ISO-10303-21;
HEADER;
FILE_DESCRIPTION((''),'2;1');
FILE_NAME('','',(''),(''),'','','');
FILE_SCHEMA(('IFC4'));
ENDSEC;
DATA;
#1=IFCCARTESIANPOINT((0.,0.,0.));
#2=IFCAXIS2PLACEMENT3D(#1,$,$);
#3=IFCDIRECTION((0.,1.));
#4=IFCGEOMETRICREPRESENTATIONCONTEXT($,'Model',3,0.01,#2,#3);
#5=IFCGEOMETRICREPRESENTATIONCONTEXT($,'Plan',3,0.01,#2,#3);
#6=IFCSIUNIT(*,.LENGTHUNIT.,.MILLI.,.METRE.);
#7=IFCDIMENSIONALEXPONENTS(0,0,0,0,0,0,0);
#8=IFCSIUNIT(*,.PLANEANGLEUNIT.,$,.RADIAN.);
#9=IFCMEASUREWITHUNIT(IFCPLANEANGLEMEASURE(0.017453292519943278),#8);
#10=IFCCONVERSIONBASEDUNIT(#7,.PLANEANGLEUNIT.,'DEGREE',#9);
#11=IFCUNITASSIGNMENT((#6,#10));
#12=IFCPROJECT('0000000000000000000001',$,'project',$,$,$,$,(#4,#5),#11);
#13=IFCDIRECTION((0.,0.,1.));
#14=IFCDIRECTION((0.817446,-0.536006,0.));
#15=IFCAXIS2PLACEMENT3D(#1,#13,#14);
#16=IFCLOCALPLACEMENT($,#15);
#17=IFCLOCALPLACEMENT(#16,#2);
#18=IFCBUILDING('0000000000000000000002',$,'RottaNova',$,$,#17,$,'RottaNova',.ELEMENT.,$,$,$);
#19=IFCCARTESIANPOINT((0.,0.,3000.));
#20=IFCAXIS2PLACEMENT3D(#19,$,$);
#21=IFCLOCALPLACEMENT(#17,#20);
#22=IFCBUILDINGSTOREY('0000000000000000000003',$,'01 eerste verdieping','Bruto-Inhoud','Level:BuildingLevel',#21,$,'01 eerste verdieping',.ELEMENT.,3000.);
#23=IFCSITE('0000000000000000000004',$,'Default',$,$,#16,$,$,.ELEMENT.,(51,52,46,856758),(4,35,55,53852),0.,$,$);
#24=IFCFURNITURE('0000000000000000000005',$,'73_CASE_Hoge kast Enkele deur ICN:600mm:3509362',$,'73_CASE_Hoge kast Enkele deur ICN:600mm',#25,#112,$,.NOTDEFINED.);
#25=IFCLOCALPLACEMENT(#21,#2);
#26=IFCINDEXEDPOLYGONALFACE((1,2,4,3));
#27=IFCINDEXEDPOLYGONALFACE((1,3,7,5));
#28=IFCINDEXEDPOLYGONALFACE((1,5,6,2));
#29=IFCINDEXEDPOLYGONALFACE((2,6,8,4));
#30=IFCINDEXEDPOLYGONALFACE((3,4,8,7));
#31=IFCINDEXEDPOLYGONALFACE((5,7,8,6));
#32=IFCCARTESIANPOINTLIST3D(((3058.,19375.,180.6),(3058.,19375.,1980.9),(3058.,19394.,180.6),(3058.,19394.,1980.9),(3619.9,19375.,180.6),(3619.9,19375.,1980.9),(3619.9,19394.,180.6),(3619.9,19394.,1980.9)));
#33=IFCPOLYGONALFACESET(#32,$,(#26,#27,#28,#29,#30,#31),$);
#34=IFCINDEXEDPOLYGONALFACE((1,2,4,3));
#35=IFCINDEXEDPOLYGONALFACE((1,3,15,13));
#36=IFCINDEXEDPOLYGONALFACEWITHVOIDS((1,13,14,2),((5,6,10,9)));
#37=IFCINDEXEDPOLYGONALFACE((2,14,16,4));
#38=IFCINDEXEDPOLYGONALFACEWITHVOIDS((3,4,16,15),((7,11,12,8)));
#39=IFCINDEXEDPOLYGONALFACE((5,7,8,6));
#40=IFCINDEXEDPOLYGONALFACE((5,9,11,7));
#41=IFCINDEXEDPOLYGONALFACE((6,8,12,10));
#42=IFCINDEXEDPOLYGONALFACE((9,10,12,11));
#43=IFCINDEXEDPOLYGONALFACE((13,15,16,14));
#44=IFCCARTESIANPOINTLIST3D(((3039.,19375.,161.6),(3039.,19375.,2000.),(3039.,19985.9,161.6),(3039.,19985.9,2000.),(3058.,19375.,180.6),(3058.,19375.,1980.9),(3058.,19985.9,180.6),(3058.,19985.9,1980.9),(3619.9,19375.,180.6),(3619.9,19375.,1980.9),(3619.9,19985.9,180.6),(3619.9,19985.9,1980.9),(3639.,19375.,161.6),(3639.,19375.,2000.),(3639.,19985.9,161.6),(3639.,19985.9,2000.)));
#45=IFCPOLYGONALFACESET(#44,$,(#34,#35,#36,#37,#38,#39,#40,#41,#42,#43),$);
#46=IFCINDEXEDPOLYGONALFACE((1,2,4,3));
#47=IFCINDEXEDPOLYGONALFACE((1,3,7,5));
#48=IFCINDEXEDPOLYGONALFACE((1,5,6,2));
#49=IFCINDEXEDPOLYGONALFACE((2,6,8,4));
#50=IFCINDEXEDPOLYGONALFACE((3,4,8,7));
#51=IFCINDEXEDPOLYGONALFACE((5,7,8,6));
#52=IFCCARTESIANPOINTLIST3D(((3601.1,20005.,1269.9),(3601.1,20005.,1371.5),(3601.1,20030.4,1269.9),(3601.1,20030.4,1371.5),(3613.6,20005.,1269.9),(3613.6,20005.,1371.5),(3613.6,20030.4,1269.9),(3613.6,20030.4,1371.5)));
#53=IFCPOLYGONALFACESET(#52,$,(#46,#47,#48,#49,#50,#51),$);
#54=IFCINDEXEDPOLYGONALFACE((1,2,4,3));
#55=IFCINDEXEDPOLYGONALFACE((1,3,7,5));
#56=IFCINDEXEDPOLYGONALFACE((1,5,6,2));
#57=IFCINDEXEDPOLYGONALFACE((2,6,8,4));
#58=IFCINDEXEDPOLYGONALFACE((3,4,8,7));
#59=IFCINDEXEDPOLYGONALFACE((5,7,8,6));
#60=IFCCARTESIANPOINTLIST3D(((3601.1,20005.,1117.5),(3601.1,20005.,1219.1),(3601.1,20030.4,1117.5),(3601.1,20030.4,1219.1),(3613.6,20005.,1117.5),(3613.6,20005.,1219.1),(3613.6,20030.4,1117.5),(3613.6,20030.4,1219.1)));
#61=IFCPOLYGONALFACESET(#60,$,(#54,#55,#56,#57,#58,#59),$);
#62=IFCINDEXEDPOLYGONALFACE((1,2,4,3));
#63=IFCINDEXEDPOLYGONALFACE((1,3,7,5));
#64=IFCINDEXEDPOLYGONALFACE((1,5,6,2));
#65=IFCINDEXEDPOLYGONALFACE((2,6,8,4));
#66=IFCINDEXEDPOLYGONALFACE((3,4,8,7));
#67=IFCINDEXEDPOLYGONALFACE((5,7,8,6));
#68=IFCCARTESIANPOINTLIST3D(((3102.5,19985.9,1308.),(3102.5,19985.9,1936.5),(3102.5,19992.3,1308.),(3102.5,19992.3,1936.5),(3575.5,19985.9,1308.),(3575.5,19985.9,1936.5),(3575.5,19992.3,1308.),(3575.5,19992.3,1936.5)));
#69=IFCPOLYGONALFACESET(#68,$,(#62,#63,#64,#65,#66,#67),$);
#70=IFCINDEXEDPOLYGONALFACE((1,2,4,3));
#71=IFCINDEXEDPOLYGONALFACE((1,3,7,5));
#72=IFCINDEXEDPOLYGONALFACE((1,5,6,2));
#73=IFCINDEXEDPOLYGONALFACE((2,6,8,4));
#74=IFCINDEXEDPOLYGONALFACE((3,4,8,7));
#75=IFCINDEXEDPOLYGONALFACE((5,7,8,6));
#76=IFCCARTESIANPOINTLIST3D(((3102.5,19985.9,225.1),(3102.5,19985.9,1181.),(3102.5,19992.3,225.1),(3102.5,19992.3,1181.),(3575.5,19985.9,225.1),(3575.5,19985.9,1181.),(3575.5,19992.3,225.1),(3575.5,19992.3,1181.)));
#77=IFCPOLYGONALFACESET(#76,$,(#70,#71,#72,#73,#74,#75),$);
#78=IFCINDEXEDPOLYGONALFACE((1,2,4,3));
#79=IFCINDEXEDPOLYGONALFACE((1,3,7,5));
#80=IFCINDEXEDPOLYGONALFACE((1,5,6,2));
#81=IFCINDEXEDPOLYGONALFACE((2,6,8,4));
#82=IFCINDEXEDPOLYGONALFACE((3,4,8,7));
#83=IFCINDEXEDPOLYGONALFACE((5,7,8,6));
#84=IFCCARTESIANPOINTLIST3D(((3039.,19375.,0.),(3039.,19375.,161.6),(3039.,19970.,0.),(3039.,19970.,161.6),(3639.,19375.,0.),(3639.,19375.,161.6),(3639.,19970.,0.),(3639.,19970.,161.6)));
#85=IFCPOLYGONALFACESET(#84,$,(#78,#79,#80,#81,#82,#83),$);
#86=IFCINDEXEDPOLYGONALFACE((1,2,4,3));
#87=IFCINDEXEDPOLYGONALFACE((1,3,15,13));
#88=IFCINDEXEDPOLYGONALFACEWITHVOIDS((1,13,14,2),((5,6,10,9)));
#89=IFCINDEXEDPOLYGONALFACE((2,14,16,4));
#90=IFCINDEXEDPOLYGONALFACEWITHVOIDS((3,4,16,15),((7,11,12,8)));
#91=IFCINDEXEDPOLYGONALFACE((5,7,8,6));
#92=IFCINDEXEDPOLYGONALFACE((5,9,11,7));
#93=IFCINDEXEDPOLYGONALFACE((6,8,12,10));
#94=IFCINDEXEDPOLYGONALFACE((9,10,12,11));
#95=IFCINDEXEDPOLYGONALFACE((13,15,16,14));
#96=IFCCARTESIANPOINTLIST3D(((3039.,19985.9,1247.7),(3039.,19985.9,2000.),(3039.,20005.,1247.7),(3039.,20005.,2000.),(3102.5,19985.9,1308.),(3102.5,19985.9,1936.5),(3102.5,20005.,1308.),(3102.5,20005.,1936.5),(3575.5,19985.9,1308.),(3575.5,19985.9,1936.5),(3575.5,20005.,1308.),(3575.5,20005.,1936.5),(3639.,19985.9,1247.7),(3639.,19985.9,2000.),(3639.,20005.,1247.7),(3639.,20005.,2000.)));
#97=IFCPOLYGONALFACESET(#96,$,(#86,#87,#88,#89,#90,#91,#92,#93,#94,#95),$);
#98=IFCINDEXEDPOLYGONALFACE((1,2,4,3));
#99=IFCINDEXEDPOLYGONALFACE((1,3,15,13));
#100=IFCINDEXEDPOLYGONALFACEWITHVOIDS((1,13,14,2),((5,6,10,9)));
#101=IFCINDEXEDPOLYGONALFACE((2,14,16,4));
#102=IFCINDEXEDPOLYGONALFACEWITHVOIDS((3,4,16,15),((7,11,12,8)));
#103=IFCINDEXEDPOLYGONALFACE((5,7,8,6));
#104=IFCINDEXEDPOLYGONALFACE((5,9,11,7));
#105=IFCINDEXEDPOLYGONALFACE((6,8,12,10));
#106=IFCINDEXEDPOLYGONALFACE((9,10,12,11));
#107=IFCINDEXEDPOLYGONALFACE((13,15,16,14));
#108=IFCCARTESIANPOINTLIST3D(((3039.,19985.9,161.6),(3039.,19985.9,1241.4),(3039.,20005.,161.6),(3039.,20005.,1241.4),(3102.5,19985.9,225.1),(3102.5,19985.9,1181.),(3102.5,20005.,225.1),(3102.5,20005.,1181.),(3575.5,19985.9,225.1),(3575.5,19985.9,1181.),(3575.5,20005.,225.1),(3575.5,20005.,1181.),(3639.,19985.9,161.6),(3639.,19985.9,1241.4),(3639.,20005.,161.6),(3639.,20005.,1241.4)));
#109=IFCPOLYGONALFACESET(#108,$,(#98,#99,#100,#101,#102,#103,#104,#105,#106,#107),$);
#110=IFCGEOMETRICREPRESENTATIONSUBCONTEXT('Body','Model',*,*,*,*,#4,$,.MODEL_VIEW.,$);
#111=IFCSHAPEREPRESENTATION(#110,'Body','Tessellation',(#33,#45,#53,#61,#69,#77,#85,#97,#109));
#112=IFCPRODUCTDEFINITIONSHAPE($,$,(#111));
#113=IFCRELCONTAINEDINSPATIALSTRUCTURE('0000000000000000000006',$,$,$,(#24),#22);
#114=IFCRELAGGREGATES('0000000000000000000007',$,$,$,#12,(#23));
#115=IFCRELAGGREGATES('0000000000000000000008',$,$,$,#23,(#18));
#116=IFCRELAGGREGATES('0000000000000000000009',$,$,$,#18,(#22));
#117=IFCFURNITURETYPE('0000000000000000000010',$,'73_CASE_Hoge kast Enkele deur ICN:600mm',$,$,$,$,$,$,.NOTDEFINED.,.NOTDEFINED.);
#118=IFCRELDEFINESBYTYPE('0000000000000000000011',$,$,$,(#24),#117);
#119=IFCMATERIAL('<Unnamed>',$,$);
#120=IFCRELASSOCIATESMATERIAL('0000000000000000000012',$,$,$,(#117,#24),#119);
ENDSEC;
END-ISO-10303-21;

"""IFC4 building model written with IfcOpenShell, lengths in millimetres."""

from ifc_helpers import new_model, entity, si_unit, converted_unit, direction, frame, origin, place, context, subcontext, project, spatial, indexed_curve, outline, extrude, source, transform, mapped, material, type_object, type_shapes, element, save


model = new_model("IFC4")

# Units and contexts
model_context = context("Model", 3, precision=0.01, world=origin(), true_north=direction((0.0, 1.0)))
plan_context = context("Plan", 3, precision=0.01, world=origin(), true_north=direction((0.0, 1.0)))
body_context = subcontext(model_context, "Body", "Model", "MODEL_VIEW")
ifc_project = project(units=[si_unit("LENGTHUNIT", "METRE", prefix="MILLI"), converted_unit("PLANEANGLEUNIT", "DEGREE", entity("IfcPlaneAngleMeasure", 0.017453292519943278), si_unit("PLANEANGLEUNIT", "RADIAN"), dimensions=[0, 0, 0, 0, 0, 0, 0])], contexts=[model_context, plan_context])

# Site, building, storey
site_placement = place(None, frame((0.0, 0.0, 0.0), z_axis=(0.0, 0.0, 1.0), x_axis=(0.817446, -0.536006, 0.0)))
site = spatial("IfcSite", under=ifc_project, at=site_placement, Name="Default", CompositionType="ELEMENT", RefLatitude=(51, 52, 46, 856758), RefLongitude=(4, 35, 55, 53852), RefElevation=0.0)
building_placement = place(site_placement, origin())
building = spatial("IfcBuilding", under=site, at=building_placement, Name="RottaNova", LongName="RottaNova", CompositionType="ELEMENT")
storey_placement = place(building_placement, frame((0.0, 0.0, 3000.0)))
storey = spatial("IfcBuildingStorey", under=building, at=storey_placement, Name="01 eerste verdieping", Description="Bruto-Inhoud", ObjectType="Level:BuildingLevel", LongName="01 eerste verdieping", CompositionType="ELEMENT", Elevation=3000.0)

# Furniture
ifc_material_1 = material(Name="<Unnamed>")
furniture_type = type_object("IfcFurnitureType", Name="73_CASE_Hoge kast Enkele deur ICN:600mm", AssemblyPlace="NOTDEFINED", PredefinedType="NOTDEFINED", material=ifc_material_1)
shared_shape_1 = source(origin(), body_context, "Body", "SweptSolid", [
    extrude(outline(indexed_curve([(-280.9, -9.5), (280.9, -9.5), (280.9, 9.5), (-280.9, 9.5), (-280.9, -9.5)], self_intersect=False)), frame((18.7, 9.5, 180.6), z_axis=(0.0, 0.0, 1.0), x_axis=(-1.0, 0.0, 0.0)), (0.0, 0.0, 1.0), 1800.3),
    extrude(outline(indexed_curve([(-300.0, -919.2), (300.0, -919.2), (300.0, 919.2), (-300.0, 919.2), (-300.0, -919.2)], self_intersect=False), holes=[indexed_curve([(-280.9, 900.2), (281.0, 900.2), (281.0, -900.2), (-280.9, -900.2), (-280.9, 900.2)], self_intersect=False)]), frame((18.7, 0.0, 1080.8), z_axis=(0.0, 1.0, 0.0), x_axis=(-1.0, 0.0, 0.0)), (0.0, 0.0, 1.0), 610.9),
    extrude(outline(indexed_curve([(-6.3, -12.7), (6.3, -12.7), (6.3, 12.7), (-6.3, 12.7), (-6.3, -12.7)], self_intersect=False)), frame((287.1, 642.7, 1269.9), z_axis=(0.0, 0.0, 1.0), x_axis=(-1.0, 0.0, 0.0)), (0.0, 0.0, 1.0), 101.6),
    extrude(outline(indexed_curve([(-6.3, -12.7), (6.3, -12.7), (6.3, 12.7), (-6.3, 12.7), (-6.3, -12.7)], self_intersect=False)), frame((287.1, 642.7, 1117.5), z_axis=(0.0, 0.0, 1.0), x_axis=(-1.0, 0.0, 0.0)), (0.0, 0.0, 1.0), 101.6),
    extrude(outline(indexed_curve([(-236.5, -3.2), (236.5, -3.2), (236.5, 3.2), (-236.5, 3.2), (-236.5, -3.2)], self_intersect=False)), frame((18.7, 614.1, 1308.0), z_axis=(0.0, 0.0, 1.0), x_axis=(-1.0, 0.0, 0.0)), (0.0, 0.0, 1.0), 628.5),
    extrude(outline(indexed_curve([(-236.5, -3.2), (236.5, -3.2), (236.5, 3.2), (-236.5, 3.2), (-236.5, -3.2)], self_intersect=False)), frame((18.7, 614.1, 225.1), z_axis=(0.0, 0.0, 1.0), x_axis=(-1.0, 0.0, 0.0)), (0.0, 0.0, 1.0), 956.0),
    extrude(outline(indexed_curve([(-297.5, -300.0), (297.5, -300.0), (297.5, 300.0), (-297.5, 300.0), (-297.5, -300.0)], self_intersect=False)), frame((18.7, 297.5, 0.0), z_axis=(0.0, 0.0, 1.0), x_axis=(0.0, 1.0, 0.0)), (0.0, 0.0, 1.0), 161.6),
    extrude(outline(indexed_curve([(-376.1, -300.0), (376.1, -300.0), (376.1, 300.0), (-376.1, 300.0), (-376.1, -300.0)], self_intersect=False), holes=[indexed_curve([(-312.6, -236.5), (-312.6, 236.5), (315.8, 236.5), (315.8, -236.5), (-312.6, -236.5)], self_intersect=False)]), frame((18.7, 610.9, 1623.9), z_axis=(0.0, 1.0, 0.0), x_axis=(0.0, 0.0, -1.0)), (0.0, 0.0, 1.0), 19.1),
    extrude(outline(indexed_curve([(-300.0, -539.9), (300.0, -539.9), (300.0, 539.9), (-300.0, 539.9), (-300.0, -539.9)], self_intersect=False), holes=[indexed_curve([(-236.5, 479.6), (236.5, 479.6), (236.5, -476.4), (-236.5, -476.4), (-236.5, 479.6)], self_intersect=False)]), frame((18.7, 610.9, 701.5), z_axis=(0.0, 1.0, 0.0), x_axis=(-1.0, 0.0, 0.0)), (0.0, 0.0, 1.0), 19.1),
])
type_shapes(furniture_type, [shared_shape_1])
for number, where, name in (
    (1, (3320.3, 19375.0, 0.0), "73_CASE_Hoge kast Enkele deur ICN:600mm:3509362"),
):
    element("IfcFurniture", number, at=place(storey_placement, frame(where)), inside=storey, type_object=furniture_type, material=ifc_material_1, Name=name, ObjectType="73_CASE_Hoge kast Enkele deur ICN:600mm", PredefinedType="NOTDEFINED", context=body_context, shape_type="MappedRepresentation", body=[
        mapped(shared_shape_1, transform((0.0, 0.0, 0.0), scale=1.0)),
    ])

save(model, "model.ifc")
